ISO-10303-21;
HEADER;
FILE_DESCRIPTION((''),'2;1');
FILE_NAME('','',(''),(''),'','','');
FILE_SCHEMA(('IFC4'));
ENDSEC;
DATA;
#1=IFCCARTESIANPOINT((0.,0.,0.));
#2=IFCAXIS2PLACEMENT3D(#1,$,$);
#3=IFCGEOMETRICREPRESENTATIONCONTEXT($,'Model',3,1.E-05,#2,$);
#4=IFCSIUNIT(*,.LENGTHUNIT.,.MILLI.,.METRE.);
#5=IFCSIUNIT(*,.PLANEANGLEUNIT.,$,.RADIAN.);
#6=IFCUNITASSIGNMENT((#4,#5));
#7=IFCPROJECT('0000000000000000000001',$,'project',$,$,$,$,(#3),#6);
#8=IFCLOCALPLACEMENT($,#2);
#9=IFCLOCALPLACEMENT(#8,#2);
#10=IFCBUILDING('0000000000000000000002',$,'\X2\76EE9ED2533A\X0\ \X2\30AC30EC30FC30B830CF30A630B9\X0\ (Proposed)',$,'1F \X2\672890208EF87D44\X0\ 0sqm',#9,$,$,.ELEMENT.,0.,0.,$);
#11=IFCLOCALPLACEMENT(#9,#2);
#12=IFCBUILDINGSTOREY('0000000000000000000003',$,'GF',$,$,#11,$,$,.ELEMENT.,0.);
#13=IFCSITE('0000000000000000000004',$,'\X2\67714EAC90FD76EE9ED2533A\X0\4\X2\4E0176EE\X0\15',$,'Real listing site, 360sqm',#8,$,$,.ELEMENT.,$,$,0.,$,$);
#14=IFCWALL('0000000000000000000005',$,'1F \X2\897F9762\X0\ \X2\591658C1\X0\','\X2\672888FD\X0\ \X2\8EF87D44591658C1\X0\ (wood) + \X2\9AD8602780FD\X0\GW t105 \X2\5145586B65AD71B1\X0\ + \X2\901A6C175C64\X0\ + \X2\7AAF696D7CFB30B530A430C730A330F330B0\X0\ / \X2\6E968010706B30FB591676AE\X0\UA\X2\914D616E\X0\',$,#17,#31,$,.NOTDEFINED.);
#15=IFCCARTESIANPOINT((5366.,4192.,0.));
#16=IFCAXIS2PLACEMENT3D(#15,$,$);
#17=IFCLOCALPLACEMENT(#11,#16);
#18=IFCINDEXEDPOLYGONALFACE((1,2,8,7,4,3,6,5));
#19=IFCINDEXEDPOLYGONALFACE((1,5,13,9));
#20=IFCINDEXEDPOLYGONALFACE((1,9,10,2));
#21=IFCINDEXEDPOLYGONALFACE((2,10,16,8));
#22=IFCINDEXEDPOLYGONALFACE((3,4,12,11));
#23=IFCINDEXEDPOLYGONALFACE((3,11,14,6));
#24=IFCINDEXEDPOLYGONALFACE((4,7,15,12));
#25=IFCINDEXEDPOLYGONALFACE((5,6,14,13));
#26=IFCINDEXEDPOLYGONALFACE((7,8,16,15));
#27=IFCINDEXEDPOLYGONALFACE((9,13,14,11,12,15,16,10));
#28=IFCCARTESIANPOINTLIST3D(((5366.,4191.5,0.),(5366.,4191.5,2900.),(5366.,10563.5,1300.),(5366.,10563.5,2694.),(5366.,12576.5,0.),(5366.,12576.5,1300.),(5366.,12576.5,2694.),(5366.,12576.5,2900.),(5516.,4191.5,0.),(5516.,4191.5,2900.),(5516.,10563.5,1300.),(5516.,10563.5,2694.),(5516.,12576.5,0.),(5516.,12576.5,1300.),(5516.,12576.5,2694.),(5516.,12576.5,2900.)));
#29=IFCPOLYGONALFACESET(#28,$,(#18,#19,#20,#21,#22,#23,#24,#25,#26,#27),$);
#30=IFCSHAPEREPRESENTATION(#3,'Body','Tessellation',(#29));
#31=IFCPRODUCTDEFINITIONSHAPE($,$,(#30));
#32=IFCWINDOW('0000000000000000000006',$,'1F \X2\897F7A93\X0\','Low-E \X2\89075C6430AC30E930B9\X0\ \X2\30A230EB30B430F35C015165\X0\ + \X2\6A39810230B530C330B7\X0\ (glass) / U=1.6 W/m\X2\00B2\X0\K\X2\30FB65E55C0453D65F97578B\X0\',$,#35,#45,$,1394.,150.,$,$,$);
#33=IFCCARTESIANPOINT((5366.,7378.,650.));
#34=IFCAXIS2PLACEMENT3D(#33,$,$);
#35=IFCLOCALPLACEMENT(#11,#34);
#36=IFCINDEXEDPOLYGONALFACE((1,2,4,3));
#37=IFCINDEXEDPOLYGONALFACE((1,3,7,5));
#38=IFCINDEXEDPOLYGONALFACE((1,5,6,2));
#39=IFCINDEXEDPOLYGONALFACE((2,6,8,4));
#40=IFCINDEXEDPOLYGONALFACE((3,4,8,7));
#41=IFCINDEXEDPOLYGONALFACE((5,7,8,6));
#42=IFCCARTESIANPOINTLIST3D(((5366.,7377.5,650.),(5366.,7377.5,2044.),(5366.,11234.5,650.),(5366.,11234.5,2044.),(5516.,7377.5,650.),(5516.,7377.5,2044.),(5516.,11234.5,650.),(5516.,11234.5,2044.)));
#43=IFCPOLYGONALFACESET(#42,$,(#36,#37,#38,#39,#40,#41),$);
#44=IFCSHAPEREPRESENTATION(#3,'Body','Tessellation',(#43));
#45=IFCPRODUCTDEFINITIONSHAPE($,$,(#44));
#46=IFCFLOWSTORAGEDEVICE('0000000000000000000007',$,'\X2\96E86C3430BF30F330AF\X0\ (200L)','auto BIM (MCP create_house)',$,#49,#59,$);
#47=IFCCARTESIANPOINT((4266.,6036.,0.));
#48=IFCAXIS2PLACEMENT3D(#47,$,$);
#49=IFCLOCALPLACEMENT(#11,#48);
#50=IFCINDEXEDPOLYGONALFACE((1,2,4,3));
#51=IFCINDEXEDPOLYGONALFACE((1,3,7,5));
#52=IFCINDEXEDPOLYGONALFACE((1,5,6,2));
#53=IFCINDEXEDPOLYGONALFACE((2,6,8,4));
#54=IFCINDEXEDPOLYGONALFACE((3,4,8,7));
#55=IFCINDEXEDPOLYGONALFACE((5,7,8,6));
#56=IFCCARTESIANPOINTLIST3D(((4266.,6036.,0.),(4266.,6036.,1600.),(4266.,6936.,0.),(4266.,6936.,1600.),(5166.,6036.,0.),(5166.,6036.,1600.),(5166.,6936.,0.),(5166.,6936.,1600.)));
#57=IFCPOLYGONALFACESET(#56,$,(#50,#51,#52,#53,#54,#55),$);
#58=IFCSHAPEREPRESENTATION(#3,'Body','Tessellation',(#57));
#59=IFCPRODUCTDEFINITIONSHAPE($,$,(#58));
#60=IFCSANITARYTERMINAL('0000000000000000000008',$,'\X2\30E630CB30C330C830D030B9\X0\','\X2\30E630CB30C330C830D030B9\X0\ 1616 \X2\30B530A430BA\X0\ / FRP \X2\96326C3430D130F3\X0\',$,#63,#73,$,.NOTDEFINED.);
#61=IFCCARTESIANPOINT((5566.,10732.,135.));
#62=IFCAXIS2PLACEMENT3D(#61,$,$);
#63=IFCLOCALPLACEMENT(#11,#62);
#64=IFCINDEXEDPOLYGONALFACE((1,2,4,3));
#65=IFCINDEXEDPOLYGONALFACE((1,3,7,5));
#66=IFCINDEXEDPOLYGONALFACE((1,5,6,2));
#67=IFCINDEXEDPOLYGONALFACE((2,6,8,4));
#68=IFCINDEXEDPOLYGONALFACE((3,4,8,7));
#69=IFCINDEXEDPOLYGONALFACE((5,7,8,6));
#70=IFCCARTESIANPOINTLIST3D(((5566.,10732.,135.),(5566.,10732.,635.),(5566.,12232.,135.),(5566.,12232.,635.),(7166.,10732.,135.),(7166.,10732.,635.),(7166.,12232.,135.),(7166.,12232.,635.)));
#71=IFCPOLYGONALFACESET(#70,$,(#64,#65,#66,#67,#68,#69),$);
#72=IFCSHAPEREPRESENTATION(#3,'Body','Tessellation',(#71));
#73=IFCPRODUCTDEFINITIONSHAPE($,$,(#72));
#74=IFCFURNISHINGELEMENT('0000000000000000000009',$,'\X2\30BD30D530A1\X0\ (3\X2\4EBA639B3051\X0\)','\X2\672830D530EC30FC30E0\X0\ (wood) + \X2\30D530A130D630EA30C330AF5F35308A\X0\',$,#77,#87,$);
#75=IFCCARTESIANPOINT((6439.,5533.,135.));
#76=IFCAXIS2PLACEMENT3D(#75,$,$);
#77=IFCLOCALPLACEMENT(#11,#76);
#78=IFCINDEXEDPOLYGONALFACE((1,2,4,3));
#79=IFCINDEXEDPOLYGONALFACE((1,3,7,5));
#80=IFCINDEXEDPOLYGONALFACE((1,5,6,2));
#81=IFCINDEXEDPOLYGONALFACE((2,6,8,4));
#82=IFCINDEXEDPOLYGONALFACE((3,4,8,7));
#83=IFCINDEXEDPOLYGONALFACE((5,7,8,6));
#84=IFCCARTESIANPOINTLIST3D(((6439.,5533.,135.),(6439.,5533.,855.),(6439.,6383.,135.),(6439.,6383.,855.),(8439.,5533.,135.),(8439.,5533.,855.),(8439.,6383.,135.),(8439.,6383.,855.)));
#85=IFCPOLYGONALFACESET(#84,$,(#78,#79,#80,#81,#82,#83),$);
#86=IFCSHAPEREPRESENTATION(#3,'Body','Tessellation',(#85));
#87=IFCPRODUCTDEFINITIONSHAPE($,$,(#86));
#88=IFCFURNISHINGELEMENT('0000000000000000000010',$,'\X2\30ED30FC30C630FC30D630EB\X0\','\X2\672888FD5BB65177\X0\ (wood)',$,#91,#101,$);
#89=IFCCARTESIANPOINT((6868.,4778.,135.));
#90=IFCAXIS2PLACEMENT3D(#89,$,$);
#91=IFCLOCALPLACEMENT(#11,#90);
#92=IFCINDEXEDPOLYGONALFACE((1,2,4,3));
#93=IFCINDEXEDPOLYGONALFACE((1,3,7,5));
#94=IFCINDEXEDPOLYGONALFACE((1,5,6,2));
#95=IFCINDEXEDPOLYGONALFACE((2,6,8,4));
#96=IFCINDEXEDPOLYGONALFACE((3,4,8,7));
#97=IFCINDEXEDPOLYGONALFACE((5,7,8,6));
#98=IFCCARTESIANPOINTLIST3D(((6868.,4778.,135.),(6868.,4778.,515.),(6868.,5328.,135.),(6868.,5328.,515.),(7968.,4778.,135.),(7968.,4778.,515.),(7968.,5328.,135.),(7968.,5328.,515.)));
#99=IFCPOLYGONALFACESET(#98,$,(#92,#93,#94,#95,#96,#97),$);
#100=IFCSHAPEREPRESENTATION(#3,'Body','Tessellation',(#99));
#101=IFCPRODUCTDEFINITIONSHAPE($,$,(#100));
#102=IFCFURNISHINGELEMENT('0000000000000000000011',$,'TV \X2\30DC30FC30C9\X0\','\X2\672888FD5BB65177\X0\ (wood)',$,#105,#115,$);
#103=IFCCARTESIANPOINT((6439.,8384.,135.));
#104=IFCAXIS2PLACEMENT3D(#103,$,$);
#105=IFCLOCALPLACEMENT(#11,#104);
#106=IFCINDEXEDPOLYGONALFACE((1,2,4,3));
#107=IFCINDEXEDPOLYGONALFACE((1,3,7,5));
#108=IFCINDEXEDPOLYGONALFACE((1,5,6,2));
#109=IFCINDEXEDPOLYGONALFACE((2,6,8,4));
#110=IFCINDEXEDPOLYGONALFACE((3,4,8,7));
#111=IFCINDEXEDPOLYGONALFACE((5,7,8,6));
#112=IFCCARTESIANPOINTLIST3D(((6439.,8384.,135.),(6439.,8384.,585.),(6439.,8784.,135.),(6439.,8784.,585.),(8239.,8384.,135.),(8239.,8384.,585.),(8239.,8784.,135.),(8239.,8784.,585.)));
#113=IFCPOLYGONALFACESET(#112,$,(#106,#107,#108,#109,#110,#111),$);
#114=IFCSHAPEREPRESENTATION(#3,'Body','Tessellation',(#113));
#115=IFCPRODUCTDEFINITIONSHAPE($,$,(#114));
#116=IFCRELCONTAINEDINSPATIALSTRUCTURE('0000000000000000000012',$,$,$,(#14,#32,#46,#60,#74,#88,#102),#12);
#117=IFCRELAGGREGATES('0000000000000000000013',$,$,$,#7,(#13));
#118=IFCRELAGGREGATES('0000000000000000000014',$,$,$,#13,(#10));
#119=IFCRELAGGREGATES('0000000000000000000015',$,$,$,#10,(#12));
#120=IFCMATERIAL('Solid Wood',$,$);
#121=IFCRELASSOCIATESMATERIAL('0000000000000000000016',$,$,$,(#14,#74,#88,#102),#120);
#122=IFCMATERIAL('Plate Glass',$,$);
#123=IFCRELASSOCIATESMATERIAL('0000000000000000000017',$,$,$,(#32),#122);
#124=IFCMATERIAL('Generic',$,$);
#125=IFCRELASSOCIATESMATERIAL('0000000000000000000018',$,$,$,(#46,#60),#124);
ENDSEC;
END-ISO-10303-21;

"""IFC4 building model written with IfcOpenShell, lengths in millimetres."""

from ifc_helpers import new_model, si_unit, frame, frame_2d, origin, place, context, project, spatial, rectangle, extrude, material, element, fill, save


model = new_model("IFC4")

# Units and contexts
model_context = context("Model", 3, precision=1e-05, world=origin())
ifc_project = project(units=[si_unit("LENGTHUNIT", "METRE", prefix="MILLI"), si_unit("PLANEANGLEUNIT", "RADIAN")], contexts=[model_context])

# Site, building, storey
site_placement = place(None, origin())
site = spatial("IfcSite", under=ifc_project, at=site_placement, Name="東京都目黒区4丁目15", ObjectType="Real listing site, 360sqm", CompositionType="ELEMENT", RefElevation=0.0)
building_placement = place(site_placement, origin())
building = spatial("IfcBuilding", under=site, at=building_placement, Name="目黒区 ガレージハウス (Proposed)", ObjectType="1F 木造軸組 0sqm", CompositionType="ELEMENT", ElevationOfRefHeight=0.0, ElevationOfTerrain=0.0)
storey_placement = place(building_placement, origin())
storey = spatial("IfcBuildingStorey", under=building, at=storey_placement, Name="GF", CompositionType="ELEMENT", Elevation=0.0)

# Shared definitions
ifc_material_1 = material(Name="Solid Wood")

# Shared definitions
ifc_material_2 = material(Name="Plate Glass")

# Wall, opening, window
wall_1_placement = place(storey_placement, frame((5366.0, 4192.0, 0.0)))
wall_1 = element("IfcWall", 1, at=wall_1_placement, inside=storey, material=ifc_material_1, Name="1F 西面 外壁", Description="木製 軸組外壁 (wood) + 高性能GW t105 充填断熱 + 通気層 + 窯業系サイディング / 準耐火・外皮UA配慮", PredefinedType="NOTDEFINED", context=model_context, shape_type="SweptSolid", body=[
    extrude(rectangle(XDim=150.0, YDim=8385.0, at=frame_2d((75.0, 4192.0))), frame((5366.0, 4192.0, 0.0)), (0.0, 0.0, 1.0), 2900.0),
])
opening_1_placement = place(storey_placement, frame((5366.0, 7378.0, 650.0)))
opening_1 = element("IfcOpeningElement", 2, at=opening_1_placement, cuts=wall_1, PredefinedType="NOTDEFINED", context=model_context, shape_type="SweptSolid", body=[
    extrude(rectangle(XDim=150.0, YDim=3857.0, at=frame_2d((75.0, 1928.0))), frame((5366.0, 7378.0, 650.0)), (0.0, 0.0, 1.0), 1394.0),
])
window_1_placement = place(storey_placement, frame((5366.0, 7378.0, 650.0)))
window_1 = element("IfcWindow", 3, at=window_1_placement, inside=storey, material=ifc_material_2, Name="1F 西窓", Description="Low-E 複層ガラス アルゴン封入 + 樹脂サッシ (glass) / U=1.6 W/m²K・日射取得型", OverallHeight=1394.0, OverallWidth=150.0, context=model_context, shape_type="SweptSolid", body=[
    extrude(rectangle(XDim=150.0, YDim=3857.0, at=frame_2d((75.0, 1928.0))), frame((5366.0, 7378.0, 650.0)), (0.0, 0.0, 1.0), 1394.0),
])
fill(opening_1, window_1)

# Shared definitions
ifc_material_3 = material(Name="Generic")

# Flow storage device
flow_storage_device_placement = place(storey_placement, frame((4266.0, 6036.0, 0.0)))
element("IfcFlowStorageDevice", 4, at=flow_storage_device_placement, inside=storey, material=ifc_material_3, Name="雨水タンク (200L)", Description="auto BIM (MCP create_house)", context=model_context, shape_type="SweptSolid", body=[
    extrude(rectangle(XDim=900.0, YDim=900.0, at=frame_2d((450.0, 450.0))), frame((4266.0, 6036.0, 0.0)), (0.0, 0.0, 1.0), 1600.0),
])

# Sanitary terminal
sanitary_terminal_placement = place(storey_placement, frame((5566.0, 10732.0, 135.0)))
element("IfcSanitaryTerminal", 5, at=sanitary_terminal_placement, inside=storey, material=ifc_material_3, Name="ユニットバス", Description="ユニットバス 1616 サイズ / FRP 防水パン", PredefinedType="NOTDEFINED", context=model_context, shape_type="SweptSolid", body=[
    extrude(rectangle(XDim=1600.0, YDim=1500.0, at=frame_2d((800.0, 750.0))), frame((5566.0, 10732.0, 135.0)), (0.0, 0.0, 1.0), 500.0),
])

# Furnishing elements
furnishing_1_placement = place(storey_placement, frame((6439.0, 5533.0, 135.0)))
element("IfcFurnishingElement", 6, at=furnishing_1_placement, inside=storey, material=ifc_material_1, Name="ソファ (3人掛け)", Description="木フレーム (wood) + ファブリック張り", context=model_context, shape_type="SweptSolid", body=[
    extrude(rectangle(XDim=2000.0, YDim=850.0, at=frame_2d((1000.0, 425.0))), frame((6439.0, 5533.0, 135.0)), (0.0, 0.0, 1.0), 720.0),
])
furnishing_2_placement = place(storey_placement, frame((6868.0, 4778.0, 135.0)))
element("IfcFurnishingElement", 7, at=furnishing_2_placement, inside=storey, material=ifc_material_1, Name="ローテーブル", Description="木製家具 (wood)", context=model_context, shape_type="SweptSolid", body=[
    extrude(rectangle(XDim=1100.0, YDim=550.0, at=frame_2d((550.0, 275.0))), frame((6868.0, 4778.0, 135.0)), (0.0, 0.0, 1.0), 380.0),
])
furnishing_3_placement = place(storey_placement, frame((6439.0, 8384.0, 135.0)))
element("IfcFurnishingElement", 8, at=furnishing_3_placement, inside=storey, material=ifc_material_1, Name="TV ボード", Description="木製家具 (wood)", context=model_context, shape_type="SweptSolid", body=[
    extrude(rectangle(XDim=1800.0, YDim=400.0, at=frame_2d((900.0, 200.0))), frame((6439.0, 8384.0, 135.0)), (0.0, 0.0, 1.0), 450.0),
])

save(model, "model.ifc")
